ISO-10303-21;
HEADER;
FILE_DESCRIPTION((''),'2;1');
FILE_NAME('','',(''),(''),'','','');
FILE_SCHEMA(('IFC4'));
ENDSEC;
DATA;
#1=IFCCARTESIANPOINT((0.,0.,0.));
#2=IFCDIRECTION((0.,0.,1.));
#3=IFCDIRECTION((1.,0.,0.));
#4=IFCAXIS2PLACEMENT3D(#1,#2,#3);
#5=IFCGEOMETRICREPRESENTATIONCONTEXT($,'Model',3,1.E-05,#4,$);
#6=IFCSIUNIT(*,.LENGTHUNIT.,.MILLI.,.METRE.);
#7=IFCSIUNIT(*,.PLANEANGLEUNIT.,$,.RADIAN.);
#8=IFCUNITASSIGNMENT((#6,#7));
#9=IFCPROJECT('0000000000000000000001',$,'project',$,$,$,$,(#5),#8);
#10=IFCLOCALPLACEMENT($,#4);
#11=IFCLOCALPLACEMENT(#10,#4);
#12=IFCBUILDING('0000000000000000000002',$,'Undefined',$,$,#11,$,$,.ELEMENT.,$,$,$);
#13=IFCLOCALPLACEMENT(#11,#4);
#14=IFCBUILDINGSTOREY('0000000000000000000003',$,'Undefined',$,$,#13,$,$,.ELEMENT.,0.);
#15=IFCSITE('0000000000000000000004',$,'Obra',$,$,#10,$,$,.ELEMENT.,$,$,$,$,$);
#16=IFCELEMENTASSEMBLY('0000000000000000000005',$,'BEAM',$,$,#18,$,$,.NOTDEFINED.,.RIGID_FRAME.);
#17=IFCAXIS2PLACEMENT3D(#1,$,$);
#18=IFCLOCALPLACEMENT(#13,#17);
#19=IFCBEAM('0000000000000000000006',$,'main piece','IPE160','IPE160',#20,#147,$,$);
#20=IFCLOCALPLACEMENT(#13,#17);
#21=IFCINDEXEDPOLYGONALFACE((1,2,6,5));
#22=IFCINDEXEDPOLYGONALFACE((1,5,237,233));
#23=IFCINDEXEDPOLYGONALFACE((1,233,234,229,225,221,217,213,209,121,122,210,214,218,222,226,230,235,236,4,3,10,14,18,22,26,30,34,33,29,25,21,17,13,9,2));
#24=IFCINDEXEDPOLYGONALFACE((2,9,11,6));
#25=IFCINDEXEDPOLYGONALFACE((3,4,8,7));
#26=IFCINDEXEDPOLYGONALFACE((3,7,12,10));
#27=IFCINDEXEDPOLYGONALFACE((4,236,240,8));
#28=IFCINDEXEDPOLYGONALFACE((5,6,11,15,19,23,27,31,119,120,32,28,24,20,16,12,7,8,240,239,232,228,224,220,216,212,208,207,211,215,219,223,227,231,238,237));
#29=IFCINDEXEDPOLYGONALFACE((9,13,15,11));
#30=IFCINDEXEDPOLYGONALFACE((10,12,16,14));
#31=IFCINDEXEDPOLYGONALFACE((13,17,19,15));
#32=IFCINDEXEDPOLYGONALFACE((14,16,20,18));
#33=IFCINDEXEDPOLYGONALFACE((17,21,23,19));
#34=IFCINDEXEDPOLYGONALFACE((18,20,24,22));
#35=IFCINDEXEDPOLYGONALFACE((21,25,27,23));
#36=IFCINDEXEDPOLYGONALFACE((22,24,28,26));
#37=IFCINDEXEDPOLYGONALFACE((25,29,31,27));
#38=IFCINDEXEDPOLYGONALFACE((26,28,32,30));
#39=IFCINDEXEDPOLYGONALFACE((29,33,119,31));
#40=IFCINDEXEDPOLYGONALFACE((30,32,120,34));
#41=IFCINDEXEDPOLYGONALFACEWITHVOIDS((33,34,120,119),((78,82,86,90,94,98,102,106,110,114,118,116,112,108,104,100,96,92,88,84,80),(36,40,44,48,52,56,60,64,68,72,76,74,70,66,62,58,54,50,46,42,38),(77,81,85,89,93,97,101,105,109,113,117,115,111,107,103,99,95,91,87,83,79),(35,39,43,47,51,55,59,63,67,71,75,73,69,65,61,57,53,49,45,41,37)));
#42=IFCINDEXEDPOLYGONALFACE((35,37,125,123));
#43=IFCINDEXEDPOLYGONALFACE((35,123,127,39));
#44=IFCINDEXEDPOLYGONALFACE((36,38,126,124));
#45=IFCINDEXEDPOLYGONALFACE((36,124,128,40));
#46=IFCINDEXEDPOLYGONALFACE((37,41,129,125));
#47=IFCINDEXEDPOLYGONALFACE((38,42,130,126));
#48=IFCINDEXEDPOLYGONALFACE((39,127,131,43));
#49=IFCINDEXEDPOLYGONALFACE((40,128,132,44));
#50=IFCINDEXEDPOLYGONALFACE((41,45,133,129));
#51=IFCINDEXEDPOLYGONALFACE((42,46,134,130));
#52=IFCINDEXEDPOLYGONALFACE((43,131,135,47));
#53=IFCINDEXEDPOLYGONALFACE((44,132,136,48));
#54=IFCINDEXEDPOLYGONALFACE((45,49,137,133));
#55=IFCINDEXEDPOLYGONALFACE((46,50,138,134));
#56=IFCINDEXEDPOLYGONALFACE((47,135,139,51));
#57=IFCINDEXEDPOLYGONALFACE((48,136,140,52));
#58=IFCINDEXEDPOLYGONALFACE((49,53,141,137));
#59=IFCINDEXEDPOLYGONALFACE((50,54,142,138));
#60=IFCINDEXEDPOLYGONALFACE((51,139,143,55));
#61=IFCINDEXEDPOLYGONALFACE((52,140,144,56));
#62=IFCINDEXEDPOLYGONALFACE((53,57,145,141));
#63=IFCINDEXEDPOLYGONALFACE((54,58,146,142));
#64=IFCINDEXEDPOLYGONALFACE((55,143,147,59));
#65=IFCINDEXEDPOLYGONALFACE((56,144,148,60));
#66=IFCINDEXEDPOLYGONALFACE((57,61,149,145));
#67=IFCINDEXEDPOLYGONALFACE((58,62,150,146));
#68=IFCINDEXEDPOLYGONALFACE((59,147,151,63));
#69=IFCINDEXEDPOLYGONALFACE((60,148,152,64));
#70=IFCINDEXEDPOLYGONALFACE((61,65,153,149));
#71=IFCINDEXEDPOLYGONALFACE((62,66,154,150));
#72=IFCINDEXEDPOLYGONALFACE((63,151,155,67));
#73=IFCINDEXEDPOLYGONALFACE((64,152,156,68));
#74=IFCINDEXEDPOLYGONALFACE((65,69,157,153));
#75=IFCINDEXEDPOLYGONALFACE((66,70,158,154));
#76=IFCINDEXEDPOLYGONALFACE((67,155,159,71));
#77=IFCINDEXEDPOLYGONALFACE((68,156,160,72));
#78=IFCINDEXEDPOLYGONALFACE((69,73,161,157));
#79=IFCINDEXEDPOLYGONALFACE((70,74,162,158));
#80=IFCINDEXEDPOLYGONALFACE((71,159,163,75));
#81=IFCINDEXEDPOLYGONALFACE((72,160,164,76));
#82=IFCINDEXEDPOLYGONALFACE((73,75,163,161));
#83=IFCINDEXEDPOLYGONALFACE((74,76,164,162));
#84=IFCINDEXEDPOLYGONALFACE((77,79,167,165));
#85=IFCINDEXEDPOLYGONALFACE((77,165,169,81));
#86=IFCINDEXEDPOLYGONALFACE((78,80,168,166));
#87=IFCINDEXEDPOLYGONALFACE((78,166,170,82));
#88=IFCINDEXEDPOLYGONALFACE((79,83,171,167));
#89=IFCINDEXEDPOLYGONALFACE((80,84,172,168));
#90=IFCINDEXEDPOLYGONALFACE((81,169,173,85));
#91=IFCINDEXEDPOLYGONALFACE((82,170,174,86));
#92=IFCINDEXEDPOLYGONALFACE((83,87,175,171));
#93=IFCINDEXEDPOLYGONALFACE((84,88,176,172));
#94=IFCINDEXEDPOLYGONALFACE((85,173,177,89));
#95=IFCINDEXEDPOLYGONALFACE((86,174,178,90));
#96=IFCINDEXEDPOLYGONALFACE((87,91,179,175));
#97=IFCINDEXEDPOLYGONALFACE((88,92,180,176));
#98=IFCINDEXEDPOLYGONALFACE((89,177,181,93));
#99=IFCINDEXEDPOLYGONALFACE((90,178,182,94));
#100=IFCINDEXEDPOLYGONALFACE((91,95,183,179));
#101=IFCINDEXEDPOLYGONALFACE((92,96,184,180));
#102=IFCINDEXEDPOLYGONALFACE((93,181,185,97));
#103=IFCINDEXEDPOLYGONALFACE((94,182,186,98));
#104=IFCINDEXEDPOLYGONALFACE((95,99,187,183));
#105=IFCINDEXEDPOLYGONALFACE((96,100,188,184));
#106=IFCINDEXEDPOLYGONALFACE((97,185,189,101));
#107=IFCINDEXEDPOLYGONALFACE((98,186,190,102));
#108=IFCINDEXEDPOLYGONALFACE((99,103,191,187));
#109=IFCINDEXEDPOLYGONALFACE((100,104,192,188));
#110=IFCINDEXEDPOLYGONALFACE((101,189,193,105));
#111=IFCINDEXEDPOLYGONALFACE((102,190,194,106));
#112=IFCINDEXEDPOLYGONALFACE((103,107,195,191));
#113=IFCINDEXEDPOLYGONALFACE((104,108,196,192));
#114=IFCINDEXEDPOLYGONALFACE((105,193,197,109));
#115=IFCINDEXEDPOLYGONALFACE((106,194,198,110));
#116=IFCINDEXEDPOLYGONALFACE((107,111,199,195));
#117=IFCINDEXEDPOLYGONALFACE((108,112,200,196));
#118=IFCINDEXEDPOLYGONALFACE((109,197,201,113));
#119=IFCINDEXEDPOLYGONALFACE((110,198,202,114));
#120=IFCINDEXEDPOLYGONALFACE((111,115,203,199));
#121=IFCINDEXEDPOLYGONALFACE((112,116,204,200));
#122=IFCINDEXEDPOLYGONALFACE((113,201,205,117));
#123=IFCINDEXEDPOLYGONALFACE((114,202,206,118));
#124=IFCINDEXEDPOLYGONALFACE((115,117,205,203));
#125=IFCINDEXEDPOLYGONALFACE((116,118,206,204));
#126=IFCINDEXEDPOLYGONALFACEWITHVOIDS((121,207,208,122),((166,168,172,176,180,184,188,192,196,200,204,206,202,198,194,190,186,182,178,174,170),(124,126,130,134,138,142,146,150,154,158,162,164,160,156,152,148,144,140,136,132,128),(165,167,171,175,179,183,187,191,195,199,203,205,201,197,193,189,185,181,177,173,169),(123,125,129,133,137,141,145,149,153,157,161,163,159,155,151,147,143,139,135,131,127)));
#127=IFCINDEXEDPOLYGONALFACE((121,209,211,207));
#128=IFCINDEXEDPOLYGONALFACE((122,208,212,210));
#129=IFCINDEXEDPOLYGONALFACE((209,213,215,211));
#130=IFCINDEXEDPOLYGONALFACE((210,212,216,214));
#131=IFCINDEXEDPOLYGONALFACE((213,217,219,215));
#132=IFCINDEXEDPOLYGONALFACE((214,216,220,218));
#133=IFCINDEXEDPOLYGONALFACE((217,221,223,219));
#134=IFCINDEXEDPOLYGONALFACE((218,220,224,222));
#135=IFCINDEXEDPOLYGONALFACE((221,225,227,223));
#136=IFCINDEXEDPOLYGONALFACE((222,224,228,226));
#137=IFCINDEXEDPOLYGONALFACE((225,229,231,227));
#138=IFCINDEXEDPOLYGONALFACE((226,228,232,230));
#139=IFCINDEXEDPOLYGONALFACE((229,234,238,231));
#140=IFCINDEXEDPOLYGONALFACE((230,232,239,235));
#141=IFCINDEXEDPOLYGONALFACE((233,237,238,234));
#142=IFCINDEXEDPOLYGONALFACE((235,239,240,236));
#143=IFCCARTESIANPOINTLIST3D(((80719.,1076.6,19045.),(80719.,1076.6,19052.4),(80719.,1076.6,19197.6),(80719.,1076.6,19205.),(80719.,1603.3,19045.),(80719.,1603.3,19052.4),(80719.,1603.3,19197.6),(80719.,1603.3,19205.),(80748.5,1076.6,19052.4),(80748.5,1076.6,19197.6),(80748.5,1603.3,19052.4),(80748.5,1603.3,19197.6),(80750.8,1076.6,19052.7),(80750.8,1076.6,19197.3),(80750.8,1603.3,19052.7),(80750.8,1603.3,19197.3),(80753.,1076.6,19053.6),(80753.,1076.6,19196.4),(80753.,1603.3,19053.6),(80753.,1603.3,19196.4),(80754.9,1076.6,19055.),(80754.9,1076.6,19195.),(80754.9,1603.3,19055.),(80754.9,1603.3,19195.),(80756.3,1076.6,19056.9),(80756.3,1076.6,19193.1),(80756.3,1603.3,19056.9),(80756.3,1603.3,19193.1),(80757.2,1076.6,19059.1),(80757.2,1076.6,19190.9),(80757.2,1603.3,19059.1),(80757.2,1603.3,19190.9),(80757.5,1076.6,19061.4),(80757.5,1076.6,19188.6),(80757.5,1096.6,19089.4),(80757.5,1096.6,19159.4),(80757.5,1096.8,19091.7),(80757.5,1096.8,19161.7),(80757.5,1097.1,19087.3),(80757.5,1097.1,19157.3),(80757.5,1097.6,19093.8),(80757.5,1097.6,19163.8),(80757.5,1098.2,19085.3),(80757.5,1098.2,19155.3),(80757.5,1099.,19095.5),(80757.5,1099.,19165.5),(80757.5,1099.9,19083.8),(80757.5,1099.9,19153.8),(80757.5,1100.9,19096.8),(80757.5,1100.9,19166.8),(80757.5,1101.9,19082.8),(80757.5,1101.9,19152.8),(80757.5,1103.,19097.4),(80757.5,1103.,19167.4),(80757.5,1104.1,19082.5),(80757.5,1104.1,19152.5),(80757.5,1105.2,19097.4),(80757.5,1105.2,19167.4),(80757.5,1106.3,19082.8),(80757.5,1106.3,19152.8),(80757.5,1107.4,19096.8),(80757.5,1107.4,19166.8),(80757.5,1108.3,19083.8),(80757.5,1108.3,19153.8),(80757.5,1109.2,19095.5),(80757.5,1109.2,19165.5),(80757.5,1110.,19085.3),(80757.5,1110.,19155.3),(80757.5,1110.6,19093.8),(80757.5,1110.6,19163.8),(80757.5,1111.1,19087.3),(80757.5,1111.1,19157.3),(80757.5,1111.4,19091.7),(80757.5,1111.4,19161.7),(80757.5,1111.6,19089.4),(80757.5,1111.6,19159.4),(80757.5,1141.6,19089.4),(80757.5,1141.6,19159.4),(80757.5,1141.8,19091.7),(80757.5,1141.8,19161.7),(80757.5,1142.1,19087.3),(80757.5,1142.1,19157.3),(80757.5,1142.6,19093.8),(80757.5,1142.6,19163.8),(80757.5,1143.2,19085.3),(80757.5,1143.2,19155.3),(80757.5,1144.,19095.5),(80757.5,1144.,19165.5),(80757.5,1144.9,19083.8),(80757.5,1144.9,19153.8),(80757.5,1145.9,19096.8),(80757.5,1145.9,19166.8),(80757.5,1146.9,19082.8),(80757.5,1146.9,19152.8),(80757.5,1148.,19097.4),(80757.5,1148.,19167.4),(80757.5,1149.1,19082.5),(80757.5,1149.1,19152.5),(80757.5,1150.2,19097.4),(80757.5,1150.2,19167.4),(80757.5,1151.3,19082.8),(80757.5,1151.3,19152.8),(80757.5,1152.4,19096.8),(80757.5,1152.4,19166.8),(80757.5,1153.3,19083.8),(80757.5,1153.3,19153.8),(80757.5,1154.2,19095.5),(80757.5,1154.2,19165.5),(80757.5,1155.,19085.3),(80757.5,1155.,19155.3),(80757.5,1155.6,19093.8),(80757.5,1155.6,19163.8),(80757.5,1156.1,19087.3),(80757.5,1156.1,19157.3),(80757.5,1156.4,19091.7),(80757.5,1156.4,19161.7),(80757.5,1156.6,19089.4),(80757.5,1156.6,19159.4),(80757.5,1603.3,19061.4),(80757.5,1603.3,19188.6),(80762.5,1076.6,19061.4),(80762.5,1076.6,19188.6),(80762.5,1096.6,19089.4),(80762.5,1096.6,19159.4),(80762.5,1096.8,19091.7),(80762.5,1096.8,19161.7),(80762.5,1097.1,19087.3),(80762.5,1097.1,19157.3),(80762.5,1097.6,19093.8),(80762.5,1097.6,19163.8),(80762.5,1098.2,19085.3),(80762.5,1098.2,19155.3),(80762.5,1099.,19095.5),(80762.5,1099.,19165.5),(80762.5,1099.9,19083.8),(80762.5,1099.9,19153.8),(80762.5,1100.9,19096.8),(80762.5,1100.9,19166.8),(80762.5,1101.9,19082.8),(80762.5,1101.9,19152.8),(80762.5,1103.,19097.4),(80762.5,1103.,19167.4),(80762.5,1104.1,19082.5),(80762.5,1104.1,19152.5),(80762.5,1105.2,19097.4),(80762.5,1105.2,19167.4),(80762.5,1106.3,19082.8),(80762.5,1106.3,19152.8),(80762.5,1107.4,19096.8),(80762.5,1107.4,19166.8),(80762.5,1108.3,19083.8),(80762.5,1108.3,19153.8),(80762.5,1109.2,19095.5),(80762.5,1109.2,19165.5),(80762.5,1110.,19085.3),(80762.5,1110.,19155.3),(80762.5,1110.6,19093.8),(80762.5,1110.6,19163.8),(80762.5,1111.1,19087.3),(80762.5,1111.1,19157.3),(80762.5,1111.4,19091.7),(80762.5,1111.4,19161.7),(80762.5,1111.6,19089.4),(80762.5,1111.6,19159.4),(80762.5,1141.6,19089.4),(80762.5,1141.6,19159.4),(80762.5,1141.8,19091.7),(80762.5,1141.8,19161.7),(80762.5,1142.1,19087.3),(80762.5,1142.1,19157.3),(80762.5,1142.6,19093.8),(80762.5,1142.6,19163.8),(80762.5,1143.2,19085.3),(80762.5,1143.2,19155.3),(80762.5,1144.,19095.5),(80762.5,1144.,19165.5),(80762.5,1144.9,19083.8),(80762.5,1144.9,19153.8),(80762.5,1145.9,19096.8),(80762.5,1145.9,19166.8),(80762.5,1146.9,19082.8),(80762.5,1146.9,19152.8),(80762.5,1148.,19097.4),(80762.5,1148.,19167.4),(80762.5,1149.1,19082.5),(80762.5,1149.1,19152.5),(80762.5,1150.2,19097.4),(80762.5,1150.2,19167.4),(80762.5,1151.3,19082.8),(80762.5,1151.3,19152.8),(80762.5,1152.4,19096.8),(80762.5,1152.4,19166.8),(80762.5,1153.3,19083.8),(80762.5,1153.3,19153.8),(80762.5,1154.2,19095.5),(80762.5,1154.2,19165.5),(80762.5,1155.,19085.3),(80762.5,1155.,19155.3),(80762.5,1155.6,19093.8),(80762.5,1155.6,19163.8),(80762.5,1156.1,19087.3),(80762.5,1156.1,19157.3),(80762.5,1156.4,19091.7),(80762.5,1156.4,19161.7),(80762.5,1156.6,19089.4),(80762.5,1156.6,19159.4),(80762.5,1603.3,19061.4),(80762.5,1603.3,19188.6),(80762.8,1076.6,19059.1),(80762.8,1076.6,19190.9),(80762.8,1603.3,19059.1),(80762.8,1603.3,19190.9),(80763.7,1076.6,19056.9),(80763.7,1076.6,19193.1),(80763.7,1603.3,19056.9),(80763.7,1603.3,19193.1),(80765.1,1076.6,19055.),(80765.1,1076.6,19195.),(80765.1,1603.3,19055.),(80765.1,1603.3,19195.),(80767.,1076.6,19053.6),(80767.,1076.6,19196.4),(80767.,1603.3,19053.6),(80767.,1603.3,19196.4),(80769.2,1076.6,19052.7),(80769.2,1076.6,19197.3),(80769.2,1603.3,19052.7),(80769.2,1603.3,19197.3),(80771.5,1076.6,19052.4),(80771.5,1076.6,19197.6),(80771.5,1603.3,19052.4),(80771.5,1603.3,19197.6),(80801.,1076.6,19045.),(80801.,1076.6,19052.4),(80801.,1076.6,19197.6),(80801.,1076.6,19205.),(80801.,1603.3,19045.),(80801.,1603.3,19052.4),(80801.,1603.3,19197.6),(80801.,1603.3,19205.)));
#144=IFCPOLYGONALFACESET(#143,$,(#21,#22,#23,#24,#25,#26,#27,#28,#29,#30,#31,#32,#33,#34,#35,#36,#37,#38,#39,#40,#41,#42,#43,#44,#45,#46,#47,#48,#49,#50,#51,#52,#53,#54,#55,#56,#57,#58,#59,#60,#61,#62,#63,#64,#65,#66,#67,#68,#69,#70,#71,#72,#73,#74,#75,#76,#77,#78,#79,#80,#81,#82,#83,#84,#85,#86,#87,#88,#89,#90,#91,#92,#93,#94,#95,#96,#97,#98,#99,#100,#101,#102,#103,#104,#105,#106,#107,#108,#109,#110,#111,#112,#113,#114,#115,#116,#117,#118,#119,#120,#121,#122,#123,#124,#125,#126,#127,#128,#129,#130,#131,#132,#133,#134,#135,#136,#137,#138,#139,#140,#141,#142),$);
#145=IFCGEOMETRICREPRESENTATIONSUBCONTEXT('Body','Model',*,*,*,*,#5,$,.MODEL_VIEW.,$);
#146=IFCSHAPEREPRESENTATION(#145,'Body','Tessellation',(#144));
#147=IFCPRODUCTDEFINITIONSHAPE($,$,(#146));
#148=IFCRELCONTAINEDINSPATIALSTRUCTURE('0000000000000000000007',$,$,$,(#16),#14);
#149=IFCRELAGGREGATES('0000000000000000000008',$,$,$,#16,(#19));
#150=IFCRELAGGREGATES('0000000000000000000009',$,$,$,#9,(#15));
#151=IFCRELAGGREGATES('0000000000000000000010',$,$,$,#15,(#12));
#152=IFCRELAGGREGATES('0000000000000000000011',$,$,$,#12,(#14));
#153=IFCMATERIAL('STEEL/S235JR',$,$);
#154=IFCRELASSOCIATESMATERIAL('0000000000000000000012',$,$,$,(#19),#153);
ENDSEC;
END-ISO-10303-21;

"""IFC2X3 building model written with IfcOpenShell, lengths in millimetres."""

from ifc_helpers import new_model, si_unit, frame, origin_with_axes, origin_2d_with_axis, place, context, subcontext, project, spatial, circle, i_section, extrude, clip, halfspace, source, transform, mapped, material, element, aggregate, save


model = new_model("IFC2X3")

# Units and contexts
model_context = context("Model", 3, precision=1e-05, world=origin_with_axes())
body_context = subcontext(model_context, "Body", "Model", "MODEL_VIEW")
ifc_project = project(units=[si_unit("LENGTHUNIT", "METRE", prefix="MILLI"), si_unit("PLANEANGLEUNIT", "RADIAN")], contexts=[model_context])

# Site, building, storey
site_placement = place(None, origin_with_axes())
site = spatial("IfcSite", under=ifc_project, at=site_placement, Name="Obra", CompositionType="ELEMENT")
building_placement = place(site_placement, origin_with_axes())
building = spatial("IfcBuilding", under=site, at=building_placement, Name="Undefined", CompositionType="ELEMENT")
storey_placement = place(building_placement, origin_with_axes())
storey = spatial("IfcBuildingStorey", under=building, at=storey_placement, Name="Undefined", CompositionType="ELEMENT", Elevation=0.0)

# Element assembly, beam, opening
ifc_material_1 = material(Name="STEEL/S235JR")
shared_shape_1 = source(origin_with_axes(), body_context, "Body", "SweptSolid", [
    extrude(circle(Radius=7.5, at=origin_2d_with_axis()), frame((0.0, -2.6, 0.0), z_axis=(0.0, 1.0, 0.0), x_axis=(1.0, 0.0, 0.0)), (0.0, 0.0, 1.0), 5.2),
])
assembly_1_placement = place(storey_placement, origin_with_axes())
assembly_1 = element("IfcElementAssembly", 1, at=assembly_1_placement, inside=storey, Name="BEAM", AssemblyPlace="NOTDEFINED", PredefinedType="RIGID_FRAME")
beam_1_placement = place(assembly_1_placement, frame((80760.0, 1086.6, 19125.0), z_axis=(0.0, 0.0, 1.0), x_axis=(0.0, 1.0, 0.0)))
beam_1 = element("IfcBeam", 2, at=beam_1_placement, material=ifc_material_1, Name="main piece", Description="IPE160", ObjectType="IPE160", context=body_context, shape_type="Clipping", body=[
    clip(extrude(i_section(OverallWidth=82.0, OverallDepth=160.0, WebThickness=5.0, FlangeThickness=7.4, FilletRadius=9.0, at=origin_2d_with_axis()), frame((516.7, 0.0, 0.0), z_axis=(-1.0, 0.0, 0.0), x_axis=(0.0, -1.0, 0.0)), (0.0, 0.0, 1.0), 526.7), halfspace(frame((-10.0, 0.0, -180.0), z_axis=(1.0, 0.0, 0.0), x_axis=(0.0, -1.0, 0.0)), True)),
])
opening_1_placement = place(assembly_1_placement, frame((80760.0, 1126.6, 19160.0), z_axis=(0.0, 1.0, 0.0), x_axis=(0.0, 0.0, -1.0)))
element("IfcOpeningElement", 3, at=opening_1_placement, cuts=beam_1, ObjectType="Opening", context=body_context, shape_type="MappedRepresentation", body=[
    mapped(shared_shape_1, transform((0.0, 0.0, -22.5))),
    mapped(shared_shape_1, transform((70.0, 0.0, -22.5))),
    mapped(shared_shape_1, transform((0.0, 0.0, 22.5))),
    mapped(shared_shape_1, transform((70.0, 0.0, 22.5))),
])
aggregate(assembly_1, [beam_1])

save(model, "model.ifc")
